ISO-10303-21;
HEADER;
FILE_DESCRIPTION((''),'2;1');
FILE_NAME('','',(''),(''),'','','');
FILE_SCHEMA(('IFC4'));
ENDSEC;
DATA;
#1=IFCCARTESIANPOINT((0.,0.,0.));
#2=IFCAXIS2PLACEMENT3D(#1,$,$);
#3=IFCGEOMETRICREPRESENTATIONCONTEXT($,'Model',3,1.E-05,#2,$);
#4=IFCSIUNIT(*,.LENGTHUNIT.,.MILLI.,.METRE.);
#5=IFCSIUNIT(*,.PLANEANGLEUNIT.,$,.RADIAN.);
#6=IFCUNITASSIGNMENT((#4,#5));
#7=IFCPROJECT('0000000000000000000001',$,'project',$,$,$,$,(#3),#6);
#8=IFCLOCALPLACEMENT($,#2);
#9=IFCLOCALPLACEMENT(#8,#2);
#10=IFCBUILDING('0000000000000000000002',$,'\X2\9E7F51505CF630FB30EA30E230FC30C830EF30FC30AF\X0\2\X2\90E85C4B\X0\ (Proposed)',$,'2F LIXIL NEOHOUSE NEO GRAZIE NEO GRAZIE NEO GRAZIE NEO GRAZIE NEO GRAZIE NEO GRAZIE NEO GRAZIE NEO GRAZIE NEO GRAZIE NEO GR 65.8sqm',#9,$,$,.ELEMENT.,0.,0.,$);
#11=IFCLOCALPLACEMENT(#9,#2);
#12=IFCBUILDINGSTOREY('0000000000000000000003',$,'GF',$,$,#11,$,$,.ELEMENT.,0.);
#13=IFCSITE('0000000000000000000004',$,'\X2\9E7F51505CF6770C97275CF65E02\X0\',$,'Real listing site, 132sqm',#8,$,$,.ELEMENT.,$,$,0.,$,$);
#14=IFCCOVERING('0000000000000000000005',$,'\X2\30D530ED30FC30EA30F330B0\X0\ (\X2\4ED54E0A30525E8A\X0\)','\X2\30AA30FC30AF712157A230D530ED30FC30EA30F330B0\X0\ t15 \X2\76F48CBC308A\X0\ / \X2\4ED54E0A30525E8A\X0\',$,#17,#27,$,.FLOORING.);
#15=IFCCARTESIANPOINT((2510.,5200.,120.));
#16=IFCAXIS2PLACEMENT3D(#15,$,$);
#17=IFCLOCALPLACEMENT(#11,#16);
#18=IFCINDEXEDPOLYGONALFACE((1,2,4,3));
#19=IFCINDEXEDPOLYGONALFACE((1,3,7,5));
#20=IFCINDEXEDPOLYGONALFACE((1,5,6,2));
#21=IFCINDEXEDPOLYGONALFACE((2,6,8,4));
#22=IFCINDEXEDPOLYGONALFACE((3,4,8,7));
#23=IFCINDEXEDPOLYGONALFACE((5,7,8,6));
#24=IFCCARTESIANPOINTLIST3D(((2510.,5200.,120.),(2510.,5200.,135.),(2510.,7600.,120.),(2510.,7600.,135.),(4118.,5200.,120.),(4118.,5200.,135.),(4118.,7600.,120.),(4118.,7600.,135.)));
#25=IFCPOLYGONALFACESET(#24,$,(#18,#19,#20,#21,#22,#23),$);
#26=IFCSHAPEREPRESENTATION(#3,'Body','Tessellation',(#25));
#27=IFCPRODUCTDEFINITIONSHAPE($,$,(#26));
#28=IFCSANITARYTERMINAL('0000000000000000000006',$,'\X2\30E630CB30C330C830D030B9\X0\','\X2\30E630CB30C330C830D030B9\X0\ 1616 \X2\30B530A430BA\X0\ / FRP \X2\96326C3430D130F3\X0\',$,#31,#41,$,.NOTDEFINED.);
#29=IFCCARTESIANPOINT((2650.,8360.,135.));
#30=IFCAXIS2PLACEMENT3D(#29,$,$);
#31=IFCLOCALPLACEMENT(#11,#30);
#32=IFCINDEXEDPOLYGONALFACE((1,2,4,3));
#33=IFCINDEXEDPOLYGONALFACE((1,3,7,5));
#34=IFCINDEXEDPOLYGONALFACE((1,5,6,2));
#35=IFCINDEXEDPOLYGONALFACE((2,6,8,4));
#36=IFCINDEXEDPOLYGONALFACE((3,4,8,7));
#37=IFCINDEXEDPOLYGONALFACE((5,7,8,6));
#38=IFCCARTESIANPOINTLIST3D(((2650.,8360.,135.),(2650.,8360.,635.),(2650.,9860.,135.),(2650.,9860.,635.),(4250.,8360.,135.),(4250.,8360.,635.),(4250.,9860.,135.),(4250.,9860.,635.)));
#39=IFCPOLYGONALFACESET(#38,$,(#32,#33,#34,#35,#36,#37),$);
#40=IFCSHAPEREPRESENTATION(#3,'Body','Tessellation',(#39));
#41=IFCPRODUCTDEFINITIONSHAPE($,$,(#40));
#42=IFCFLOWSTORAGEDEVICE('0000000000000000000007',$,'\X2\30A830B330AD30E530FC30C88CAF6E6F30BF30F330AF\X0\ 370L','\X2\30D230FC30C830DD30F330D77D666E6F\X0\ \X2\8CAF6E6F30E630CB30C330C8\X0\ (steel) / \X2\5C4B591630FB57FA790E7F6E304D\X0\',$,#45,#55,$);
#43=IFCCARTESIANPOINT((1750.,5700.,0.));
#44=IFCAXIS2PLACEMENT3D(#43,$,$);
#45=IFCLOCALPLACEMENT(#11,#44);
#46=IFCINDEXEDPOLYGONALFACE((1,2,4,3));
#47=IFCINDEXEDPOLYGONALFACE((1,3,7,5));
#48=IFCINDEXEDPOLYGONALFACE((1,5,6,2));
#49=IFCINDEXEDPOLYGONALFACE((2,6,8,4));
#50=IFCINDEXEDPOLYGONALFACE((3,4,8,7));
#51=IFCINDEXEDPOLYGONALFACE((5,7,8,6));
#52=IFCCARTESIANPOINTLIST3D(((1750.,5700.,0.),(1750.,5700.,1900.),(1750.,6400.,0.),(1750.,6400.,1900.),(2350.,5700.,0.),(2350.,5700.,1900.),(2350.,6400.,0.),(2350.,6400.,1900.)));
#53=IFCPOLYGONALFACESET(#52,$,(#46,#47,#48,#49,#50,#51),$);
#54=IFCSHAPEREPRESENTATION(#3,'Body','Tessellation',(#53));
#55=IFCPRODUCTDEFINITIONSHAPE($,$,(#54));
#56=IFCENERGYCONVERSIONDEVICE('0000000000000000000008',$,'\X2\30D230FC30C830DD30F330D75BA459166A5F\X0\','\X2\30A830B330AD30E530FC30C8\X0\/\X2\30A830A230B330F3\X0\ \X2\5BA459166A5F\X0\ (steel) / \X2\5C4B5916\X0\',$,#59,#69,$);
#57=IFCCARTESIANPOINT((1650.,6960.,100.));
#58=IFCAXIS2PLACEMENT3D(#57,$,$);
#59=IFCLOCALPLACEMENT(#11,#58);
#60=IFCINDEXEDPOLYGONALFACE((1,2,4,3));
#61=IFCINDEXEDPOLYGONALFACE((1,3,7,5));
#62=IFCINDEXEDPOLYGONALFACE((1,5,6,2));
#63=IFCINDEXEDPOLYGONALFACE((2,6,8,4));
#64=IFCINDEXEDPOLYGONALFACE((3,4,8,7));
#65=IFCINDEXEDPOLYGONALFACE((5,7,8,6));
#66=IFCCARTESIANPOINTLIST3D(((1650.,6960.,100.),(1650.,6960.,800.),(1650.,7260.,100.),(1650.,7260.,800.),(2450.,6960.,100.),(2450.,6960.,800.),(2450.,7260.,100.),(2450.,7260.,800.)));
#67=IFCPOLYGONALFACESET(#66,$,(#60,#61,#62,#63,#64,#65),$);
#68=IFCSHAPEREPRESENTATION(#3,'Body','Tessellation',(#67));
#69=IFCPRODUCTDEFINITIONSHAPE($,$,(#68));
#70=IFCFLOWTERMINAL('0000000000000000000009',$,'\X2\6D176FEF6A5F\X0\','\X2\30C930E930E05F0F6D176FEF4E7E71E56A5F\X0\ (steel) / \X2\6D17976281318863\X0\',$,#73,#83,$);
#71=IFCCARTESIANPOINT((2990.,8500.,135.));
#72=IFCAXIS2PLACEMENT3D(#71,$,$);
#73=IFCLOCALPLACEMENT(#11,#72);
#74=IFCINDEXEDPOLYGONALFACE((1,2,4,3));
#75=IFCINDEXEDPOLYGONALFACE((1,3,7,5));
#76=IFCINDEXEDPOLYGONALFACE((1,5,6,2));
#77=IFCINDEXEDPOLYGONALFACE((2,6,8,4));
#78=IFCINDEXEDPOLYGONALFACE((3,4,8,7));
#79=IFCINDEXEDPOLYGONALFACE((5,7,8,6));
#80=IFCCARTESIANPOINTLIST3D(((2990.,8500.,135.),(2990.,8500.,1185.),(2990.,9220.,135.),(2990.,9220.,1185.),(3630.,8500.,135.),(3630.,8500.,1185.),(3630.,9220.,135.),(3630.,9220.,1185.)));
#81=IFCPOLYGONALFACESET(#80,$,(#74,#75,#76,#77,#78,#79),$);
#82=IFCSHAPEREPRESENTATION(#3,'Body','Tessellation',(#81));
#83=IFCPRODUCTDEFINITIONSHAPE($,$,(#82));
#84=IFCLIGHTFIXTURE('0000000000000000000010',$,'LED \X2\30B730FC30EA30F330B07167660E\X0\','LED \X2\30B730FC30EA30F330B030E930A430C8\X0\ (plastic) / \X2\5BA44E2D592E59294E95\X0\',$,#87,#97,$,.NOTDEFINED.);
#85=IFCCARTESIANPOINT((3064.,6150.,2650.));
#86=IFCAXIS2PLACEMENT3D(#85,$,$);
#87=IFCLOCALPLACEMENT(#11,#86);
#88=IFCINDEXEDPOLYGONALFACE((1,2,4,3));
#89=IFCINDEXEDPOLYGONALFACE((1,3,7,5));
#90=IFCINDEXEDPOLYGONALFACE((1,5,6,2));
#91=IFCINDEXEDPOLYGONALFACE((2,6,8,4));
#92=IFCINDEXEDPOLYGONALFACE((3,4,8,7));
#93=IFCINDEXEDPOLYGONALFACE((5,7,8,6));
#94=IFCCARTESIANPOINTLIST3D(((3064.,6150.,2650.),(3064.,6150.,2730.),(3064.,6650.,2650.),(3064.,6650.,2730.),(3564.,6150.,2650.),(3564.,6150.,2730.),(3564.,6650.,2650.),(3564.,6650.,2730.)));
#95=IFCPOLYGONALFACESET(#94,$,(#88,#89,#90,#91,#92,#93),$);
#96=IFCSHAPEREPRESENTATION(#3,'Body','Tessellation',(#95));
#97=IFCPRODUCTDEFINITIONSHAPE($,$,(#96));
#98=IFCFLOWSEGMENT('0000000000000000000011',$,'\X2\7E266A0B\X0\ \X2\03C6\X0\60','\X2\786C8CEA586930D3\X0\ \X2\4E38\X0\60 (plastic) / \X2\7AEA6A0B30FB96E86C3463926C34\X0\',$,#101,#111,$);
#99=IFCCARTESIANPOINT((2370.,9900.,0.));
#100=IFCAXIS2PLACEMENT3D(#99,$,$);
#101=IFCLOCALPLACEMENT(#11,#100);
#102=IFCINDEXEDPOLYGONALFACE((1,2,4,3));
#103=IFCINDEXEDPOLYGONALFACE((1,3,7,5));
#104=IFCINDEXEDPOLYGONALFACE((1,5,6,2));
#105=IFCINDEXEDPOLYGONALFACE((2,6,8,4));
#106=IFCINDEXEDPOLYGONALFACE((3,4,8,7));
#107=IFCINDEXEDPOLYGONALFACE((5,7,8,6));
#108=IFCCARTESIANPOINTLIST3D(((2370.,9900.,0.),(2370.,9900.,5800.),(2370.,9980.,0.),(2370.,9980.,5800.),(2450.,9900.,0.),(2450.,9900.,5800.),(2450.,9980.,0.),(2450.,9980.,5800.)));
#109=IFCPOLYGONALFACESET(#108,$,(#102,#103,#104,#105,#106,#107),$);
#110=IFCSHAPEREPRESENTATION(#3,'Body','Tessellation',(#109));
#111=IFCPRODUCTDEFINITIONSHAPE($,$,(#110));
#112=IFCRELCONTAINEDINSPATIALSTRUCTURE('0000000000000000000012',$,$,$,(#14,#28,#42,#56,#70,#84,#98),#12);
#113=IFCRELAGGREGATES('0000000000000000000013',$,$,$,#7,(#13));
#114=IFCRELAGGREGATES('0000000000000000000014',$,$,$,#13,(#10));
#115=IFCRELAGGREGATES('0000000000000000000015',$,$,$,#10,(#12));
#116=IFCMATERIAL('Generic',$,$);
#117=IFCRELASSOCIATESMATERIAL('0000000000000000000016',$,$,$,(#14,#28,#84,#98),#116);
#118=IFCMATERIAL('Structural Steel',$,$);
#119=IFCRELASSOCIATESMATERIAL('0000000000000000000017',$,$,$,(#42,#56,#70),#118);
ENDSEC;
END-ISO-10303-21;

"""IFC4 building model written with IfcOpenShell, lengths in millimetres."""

from ifc_helpers import new_model, si_unit, frame, frame_2d, origin, place, context, project, spatial, rectangle, extrude, material, element, save


model = new_model("IFC4")

# Units and contexts
model_context = context("Model", 3, precision=1e-05, world=origin())
ifc_project = project(units=[si_unit("LENGTHUNIT", "METRE", prefix="MILLI"), si_unit("PLANEANGLEUNIT", "RADIAN")], contexts=[model_context])

# Site, building, storey
site_placement = place(None, origin())
site = spatial("IfcSite", under=ifc_project, at=site_placement, Name="鹿児島県霧島市", ObjectType="Real listing site, 132sqm", CompositionType="ELEMENT", RefElevation=0.0)
building_placement = place(site_placement, origin())
building = spatial("IfcBuilding", under=site, at=building_placement, Name="鹿児島・リモートワーク2部屋 (Proposed)", ObjectType="2F LIXIL NEOHOUSE NEO GRAZIE NEO GRAZIE NEO GRAZIE NEO GRAZIE NEO GRAZIE NEO GRAZIE NEO GRAZIE NEO GRAZIE NEO GRAZIE NEO GR 65.8sqm", CompositionType="ELEMENT", ElevationOfRefHeight=0.0, ElevationOfTerrain=0.0)
storey_placement = place(building_placement, origin())
storey = spatial("IfcBuildingStorey", under=building, at=storey_placement, Name="GF", CompositionType="ELEMENT", Elevation=0.0)

# Covering
ifc_material_1 = material(Name="Generic")
covering_1_placement = place(storey_placement, frame((2510.0, 5200.0, 120.0)))
element("IfcCovering", 1, at=covering_1_placement, inside=storey, material=ifc_material_1, Name="フローリング (仕上げ床)", Description="オーク無垢フローリング t15 直貼り / 仕上げ床", PredefinedType="FLOORING", context=model_context, shape_type="SweptSolid", body=[
    extrude(rectangle(XDim=1608.0, YDim=2400.0, at=frame_2d((804.0, 1200.0))), frame((2510.0, 5200.0, 120.0)), (0.0, 0.0, 1.0), 15.0),
])

# Sanitary terminal
sanitary_terminal_placement = place(storey_placement, frame((2650.0, 8360.0, 135.0)))
element("IfcSanitaryTerminal", 2, at=sanitary_terminal_placement, inside=storey, material=ifc_material_1, Name="ユニットバス", Description="ユニットバス 1616 サイズ / FRP 防水パン", PredefinedType="NOTDEFINED", context=model_context, shape_type="SweptSolid", body=[
    extrude(rectangle(XDim=1600.0, YDim=1500.0, at=frame_2d((800.0, 750.0))), frame((2650.0, 8360.0, 135.0)), (0.0, 0.0, 1.0), 500.0),
])

# Flow storage device
ifc_material_2 = material(Name="Structural Steel")
flow_storage_device_placement = place(storey_placement, frame((1750.0, 5700.0, 0.0)))
element("IfcFlowStorageDevice", 3, at=flow_storage_device_placement, inside=storey, material=ifc_material_2, Name="エコキュート貯湯タンク 370L", Description="ヒートポンプ給湯 貯湯ユニット (steel) / 屋外・基礎置き", context=model_context, shape_type="SweptSolid", body=[
    extrude(rectangle(XDim=600.0, YDim=700.0, at=frame_2d((300.0, 350.0))), frame((1750.0, 5700.0, 0.0)), (0.0, 0.0, 1.0), 1900.0),
])

# Energy conversion device
energy_conversion_device_placement = place(storey_placement, frame((1650.0, 6960.0, 100.0)))
element("IfcEnergyConversionDevice", 4, at=energy_conversion_device_placement, inside=storey, material=ifc_material_2, Name="ヒートポンプ室外機", Description="エコキュート/エアコン 室外機 (steel) / 屋外", context=model_context, shape_type="SweptSolid", body=[
    extrude(rectangle(XDim=800.0, YDim=300.0, at=frame_2d((400.0, 150.0))), frame((1650.0, 6960.0, 100.0)), (0.0, 0.0, 1.0), 700.0),
])

# Flow terminal
flow_terminal_placement = place(storey_placement, frame((2990.0, 8500.0, 135.0)))
element("IfcFlowTerminal", 5, at=flow_terminal_placement, inside=storey, material=ifc_material_2, Name="洗濯機", Description="ドラム式洗濯乾燥機 (steel) / 洗面脱衣", context=model_context, shape_type="SweptSolid", body=[
    extrude(rectangle(XDim=640.0, YDim=720.0, at=frame_2d((320.0, 360.0))), frame((2990.0, 8500.0, 135.0)), (0.0, 0.0, 1.0), 1050.0),
])

# Light fixture
light_fixture_placement = place(storey_placement, frame((3064.0, 6150.0, 2650.0)))
element("IfcLightFixture", 6, at=light_fixture_placement, inside=storey, material=ifc_material_1, Name="LED シーリング照明", Description="LED シーリングライト (plastic) / 室中央天井", PredefinedType="NOTDEFINED", context=model_context, shape_type="SweptSolid", body=[
    extrude(rectangle(XDim=500.0, YDim=500.0, at=frame_2d((250.0, 250.0))), frame((3064.0, 6150.0, 2650.0)), (0.0, 0.0, 1.0), 80.0),
])

# Flow segment
flow_segment_placement = place(storey_placement, frame((2370.0, 9900.0, 0.0)))
element("IfcFlowSegment", 7, at=flow_segment_placement, inside=storey, material=ifc_material_1, Name="縦樋 φ60", Description="硬質塩ビ 丸60 (plastic) / 竪樋・雨水排水", context=model_context, shape_type="SweptSolid", body=[
    extrude(rectangle(XDim=80.0, YDim=80.0, at=frame_2d((40.0, 40.0))), frame((2370.0, 9900.0, 0.0)), (0.0, 0.0, 1.0), 5800.0),
])

save(model, "model.ifc")
